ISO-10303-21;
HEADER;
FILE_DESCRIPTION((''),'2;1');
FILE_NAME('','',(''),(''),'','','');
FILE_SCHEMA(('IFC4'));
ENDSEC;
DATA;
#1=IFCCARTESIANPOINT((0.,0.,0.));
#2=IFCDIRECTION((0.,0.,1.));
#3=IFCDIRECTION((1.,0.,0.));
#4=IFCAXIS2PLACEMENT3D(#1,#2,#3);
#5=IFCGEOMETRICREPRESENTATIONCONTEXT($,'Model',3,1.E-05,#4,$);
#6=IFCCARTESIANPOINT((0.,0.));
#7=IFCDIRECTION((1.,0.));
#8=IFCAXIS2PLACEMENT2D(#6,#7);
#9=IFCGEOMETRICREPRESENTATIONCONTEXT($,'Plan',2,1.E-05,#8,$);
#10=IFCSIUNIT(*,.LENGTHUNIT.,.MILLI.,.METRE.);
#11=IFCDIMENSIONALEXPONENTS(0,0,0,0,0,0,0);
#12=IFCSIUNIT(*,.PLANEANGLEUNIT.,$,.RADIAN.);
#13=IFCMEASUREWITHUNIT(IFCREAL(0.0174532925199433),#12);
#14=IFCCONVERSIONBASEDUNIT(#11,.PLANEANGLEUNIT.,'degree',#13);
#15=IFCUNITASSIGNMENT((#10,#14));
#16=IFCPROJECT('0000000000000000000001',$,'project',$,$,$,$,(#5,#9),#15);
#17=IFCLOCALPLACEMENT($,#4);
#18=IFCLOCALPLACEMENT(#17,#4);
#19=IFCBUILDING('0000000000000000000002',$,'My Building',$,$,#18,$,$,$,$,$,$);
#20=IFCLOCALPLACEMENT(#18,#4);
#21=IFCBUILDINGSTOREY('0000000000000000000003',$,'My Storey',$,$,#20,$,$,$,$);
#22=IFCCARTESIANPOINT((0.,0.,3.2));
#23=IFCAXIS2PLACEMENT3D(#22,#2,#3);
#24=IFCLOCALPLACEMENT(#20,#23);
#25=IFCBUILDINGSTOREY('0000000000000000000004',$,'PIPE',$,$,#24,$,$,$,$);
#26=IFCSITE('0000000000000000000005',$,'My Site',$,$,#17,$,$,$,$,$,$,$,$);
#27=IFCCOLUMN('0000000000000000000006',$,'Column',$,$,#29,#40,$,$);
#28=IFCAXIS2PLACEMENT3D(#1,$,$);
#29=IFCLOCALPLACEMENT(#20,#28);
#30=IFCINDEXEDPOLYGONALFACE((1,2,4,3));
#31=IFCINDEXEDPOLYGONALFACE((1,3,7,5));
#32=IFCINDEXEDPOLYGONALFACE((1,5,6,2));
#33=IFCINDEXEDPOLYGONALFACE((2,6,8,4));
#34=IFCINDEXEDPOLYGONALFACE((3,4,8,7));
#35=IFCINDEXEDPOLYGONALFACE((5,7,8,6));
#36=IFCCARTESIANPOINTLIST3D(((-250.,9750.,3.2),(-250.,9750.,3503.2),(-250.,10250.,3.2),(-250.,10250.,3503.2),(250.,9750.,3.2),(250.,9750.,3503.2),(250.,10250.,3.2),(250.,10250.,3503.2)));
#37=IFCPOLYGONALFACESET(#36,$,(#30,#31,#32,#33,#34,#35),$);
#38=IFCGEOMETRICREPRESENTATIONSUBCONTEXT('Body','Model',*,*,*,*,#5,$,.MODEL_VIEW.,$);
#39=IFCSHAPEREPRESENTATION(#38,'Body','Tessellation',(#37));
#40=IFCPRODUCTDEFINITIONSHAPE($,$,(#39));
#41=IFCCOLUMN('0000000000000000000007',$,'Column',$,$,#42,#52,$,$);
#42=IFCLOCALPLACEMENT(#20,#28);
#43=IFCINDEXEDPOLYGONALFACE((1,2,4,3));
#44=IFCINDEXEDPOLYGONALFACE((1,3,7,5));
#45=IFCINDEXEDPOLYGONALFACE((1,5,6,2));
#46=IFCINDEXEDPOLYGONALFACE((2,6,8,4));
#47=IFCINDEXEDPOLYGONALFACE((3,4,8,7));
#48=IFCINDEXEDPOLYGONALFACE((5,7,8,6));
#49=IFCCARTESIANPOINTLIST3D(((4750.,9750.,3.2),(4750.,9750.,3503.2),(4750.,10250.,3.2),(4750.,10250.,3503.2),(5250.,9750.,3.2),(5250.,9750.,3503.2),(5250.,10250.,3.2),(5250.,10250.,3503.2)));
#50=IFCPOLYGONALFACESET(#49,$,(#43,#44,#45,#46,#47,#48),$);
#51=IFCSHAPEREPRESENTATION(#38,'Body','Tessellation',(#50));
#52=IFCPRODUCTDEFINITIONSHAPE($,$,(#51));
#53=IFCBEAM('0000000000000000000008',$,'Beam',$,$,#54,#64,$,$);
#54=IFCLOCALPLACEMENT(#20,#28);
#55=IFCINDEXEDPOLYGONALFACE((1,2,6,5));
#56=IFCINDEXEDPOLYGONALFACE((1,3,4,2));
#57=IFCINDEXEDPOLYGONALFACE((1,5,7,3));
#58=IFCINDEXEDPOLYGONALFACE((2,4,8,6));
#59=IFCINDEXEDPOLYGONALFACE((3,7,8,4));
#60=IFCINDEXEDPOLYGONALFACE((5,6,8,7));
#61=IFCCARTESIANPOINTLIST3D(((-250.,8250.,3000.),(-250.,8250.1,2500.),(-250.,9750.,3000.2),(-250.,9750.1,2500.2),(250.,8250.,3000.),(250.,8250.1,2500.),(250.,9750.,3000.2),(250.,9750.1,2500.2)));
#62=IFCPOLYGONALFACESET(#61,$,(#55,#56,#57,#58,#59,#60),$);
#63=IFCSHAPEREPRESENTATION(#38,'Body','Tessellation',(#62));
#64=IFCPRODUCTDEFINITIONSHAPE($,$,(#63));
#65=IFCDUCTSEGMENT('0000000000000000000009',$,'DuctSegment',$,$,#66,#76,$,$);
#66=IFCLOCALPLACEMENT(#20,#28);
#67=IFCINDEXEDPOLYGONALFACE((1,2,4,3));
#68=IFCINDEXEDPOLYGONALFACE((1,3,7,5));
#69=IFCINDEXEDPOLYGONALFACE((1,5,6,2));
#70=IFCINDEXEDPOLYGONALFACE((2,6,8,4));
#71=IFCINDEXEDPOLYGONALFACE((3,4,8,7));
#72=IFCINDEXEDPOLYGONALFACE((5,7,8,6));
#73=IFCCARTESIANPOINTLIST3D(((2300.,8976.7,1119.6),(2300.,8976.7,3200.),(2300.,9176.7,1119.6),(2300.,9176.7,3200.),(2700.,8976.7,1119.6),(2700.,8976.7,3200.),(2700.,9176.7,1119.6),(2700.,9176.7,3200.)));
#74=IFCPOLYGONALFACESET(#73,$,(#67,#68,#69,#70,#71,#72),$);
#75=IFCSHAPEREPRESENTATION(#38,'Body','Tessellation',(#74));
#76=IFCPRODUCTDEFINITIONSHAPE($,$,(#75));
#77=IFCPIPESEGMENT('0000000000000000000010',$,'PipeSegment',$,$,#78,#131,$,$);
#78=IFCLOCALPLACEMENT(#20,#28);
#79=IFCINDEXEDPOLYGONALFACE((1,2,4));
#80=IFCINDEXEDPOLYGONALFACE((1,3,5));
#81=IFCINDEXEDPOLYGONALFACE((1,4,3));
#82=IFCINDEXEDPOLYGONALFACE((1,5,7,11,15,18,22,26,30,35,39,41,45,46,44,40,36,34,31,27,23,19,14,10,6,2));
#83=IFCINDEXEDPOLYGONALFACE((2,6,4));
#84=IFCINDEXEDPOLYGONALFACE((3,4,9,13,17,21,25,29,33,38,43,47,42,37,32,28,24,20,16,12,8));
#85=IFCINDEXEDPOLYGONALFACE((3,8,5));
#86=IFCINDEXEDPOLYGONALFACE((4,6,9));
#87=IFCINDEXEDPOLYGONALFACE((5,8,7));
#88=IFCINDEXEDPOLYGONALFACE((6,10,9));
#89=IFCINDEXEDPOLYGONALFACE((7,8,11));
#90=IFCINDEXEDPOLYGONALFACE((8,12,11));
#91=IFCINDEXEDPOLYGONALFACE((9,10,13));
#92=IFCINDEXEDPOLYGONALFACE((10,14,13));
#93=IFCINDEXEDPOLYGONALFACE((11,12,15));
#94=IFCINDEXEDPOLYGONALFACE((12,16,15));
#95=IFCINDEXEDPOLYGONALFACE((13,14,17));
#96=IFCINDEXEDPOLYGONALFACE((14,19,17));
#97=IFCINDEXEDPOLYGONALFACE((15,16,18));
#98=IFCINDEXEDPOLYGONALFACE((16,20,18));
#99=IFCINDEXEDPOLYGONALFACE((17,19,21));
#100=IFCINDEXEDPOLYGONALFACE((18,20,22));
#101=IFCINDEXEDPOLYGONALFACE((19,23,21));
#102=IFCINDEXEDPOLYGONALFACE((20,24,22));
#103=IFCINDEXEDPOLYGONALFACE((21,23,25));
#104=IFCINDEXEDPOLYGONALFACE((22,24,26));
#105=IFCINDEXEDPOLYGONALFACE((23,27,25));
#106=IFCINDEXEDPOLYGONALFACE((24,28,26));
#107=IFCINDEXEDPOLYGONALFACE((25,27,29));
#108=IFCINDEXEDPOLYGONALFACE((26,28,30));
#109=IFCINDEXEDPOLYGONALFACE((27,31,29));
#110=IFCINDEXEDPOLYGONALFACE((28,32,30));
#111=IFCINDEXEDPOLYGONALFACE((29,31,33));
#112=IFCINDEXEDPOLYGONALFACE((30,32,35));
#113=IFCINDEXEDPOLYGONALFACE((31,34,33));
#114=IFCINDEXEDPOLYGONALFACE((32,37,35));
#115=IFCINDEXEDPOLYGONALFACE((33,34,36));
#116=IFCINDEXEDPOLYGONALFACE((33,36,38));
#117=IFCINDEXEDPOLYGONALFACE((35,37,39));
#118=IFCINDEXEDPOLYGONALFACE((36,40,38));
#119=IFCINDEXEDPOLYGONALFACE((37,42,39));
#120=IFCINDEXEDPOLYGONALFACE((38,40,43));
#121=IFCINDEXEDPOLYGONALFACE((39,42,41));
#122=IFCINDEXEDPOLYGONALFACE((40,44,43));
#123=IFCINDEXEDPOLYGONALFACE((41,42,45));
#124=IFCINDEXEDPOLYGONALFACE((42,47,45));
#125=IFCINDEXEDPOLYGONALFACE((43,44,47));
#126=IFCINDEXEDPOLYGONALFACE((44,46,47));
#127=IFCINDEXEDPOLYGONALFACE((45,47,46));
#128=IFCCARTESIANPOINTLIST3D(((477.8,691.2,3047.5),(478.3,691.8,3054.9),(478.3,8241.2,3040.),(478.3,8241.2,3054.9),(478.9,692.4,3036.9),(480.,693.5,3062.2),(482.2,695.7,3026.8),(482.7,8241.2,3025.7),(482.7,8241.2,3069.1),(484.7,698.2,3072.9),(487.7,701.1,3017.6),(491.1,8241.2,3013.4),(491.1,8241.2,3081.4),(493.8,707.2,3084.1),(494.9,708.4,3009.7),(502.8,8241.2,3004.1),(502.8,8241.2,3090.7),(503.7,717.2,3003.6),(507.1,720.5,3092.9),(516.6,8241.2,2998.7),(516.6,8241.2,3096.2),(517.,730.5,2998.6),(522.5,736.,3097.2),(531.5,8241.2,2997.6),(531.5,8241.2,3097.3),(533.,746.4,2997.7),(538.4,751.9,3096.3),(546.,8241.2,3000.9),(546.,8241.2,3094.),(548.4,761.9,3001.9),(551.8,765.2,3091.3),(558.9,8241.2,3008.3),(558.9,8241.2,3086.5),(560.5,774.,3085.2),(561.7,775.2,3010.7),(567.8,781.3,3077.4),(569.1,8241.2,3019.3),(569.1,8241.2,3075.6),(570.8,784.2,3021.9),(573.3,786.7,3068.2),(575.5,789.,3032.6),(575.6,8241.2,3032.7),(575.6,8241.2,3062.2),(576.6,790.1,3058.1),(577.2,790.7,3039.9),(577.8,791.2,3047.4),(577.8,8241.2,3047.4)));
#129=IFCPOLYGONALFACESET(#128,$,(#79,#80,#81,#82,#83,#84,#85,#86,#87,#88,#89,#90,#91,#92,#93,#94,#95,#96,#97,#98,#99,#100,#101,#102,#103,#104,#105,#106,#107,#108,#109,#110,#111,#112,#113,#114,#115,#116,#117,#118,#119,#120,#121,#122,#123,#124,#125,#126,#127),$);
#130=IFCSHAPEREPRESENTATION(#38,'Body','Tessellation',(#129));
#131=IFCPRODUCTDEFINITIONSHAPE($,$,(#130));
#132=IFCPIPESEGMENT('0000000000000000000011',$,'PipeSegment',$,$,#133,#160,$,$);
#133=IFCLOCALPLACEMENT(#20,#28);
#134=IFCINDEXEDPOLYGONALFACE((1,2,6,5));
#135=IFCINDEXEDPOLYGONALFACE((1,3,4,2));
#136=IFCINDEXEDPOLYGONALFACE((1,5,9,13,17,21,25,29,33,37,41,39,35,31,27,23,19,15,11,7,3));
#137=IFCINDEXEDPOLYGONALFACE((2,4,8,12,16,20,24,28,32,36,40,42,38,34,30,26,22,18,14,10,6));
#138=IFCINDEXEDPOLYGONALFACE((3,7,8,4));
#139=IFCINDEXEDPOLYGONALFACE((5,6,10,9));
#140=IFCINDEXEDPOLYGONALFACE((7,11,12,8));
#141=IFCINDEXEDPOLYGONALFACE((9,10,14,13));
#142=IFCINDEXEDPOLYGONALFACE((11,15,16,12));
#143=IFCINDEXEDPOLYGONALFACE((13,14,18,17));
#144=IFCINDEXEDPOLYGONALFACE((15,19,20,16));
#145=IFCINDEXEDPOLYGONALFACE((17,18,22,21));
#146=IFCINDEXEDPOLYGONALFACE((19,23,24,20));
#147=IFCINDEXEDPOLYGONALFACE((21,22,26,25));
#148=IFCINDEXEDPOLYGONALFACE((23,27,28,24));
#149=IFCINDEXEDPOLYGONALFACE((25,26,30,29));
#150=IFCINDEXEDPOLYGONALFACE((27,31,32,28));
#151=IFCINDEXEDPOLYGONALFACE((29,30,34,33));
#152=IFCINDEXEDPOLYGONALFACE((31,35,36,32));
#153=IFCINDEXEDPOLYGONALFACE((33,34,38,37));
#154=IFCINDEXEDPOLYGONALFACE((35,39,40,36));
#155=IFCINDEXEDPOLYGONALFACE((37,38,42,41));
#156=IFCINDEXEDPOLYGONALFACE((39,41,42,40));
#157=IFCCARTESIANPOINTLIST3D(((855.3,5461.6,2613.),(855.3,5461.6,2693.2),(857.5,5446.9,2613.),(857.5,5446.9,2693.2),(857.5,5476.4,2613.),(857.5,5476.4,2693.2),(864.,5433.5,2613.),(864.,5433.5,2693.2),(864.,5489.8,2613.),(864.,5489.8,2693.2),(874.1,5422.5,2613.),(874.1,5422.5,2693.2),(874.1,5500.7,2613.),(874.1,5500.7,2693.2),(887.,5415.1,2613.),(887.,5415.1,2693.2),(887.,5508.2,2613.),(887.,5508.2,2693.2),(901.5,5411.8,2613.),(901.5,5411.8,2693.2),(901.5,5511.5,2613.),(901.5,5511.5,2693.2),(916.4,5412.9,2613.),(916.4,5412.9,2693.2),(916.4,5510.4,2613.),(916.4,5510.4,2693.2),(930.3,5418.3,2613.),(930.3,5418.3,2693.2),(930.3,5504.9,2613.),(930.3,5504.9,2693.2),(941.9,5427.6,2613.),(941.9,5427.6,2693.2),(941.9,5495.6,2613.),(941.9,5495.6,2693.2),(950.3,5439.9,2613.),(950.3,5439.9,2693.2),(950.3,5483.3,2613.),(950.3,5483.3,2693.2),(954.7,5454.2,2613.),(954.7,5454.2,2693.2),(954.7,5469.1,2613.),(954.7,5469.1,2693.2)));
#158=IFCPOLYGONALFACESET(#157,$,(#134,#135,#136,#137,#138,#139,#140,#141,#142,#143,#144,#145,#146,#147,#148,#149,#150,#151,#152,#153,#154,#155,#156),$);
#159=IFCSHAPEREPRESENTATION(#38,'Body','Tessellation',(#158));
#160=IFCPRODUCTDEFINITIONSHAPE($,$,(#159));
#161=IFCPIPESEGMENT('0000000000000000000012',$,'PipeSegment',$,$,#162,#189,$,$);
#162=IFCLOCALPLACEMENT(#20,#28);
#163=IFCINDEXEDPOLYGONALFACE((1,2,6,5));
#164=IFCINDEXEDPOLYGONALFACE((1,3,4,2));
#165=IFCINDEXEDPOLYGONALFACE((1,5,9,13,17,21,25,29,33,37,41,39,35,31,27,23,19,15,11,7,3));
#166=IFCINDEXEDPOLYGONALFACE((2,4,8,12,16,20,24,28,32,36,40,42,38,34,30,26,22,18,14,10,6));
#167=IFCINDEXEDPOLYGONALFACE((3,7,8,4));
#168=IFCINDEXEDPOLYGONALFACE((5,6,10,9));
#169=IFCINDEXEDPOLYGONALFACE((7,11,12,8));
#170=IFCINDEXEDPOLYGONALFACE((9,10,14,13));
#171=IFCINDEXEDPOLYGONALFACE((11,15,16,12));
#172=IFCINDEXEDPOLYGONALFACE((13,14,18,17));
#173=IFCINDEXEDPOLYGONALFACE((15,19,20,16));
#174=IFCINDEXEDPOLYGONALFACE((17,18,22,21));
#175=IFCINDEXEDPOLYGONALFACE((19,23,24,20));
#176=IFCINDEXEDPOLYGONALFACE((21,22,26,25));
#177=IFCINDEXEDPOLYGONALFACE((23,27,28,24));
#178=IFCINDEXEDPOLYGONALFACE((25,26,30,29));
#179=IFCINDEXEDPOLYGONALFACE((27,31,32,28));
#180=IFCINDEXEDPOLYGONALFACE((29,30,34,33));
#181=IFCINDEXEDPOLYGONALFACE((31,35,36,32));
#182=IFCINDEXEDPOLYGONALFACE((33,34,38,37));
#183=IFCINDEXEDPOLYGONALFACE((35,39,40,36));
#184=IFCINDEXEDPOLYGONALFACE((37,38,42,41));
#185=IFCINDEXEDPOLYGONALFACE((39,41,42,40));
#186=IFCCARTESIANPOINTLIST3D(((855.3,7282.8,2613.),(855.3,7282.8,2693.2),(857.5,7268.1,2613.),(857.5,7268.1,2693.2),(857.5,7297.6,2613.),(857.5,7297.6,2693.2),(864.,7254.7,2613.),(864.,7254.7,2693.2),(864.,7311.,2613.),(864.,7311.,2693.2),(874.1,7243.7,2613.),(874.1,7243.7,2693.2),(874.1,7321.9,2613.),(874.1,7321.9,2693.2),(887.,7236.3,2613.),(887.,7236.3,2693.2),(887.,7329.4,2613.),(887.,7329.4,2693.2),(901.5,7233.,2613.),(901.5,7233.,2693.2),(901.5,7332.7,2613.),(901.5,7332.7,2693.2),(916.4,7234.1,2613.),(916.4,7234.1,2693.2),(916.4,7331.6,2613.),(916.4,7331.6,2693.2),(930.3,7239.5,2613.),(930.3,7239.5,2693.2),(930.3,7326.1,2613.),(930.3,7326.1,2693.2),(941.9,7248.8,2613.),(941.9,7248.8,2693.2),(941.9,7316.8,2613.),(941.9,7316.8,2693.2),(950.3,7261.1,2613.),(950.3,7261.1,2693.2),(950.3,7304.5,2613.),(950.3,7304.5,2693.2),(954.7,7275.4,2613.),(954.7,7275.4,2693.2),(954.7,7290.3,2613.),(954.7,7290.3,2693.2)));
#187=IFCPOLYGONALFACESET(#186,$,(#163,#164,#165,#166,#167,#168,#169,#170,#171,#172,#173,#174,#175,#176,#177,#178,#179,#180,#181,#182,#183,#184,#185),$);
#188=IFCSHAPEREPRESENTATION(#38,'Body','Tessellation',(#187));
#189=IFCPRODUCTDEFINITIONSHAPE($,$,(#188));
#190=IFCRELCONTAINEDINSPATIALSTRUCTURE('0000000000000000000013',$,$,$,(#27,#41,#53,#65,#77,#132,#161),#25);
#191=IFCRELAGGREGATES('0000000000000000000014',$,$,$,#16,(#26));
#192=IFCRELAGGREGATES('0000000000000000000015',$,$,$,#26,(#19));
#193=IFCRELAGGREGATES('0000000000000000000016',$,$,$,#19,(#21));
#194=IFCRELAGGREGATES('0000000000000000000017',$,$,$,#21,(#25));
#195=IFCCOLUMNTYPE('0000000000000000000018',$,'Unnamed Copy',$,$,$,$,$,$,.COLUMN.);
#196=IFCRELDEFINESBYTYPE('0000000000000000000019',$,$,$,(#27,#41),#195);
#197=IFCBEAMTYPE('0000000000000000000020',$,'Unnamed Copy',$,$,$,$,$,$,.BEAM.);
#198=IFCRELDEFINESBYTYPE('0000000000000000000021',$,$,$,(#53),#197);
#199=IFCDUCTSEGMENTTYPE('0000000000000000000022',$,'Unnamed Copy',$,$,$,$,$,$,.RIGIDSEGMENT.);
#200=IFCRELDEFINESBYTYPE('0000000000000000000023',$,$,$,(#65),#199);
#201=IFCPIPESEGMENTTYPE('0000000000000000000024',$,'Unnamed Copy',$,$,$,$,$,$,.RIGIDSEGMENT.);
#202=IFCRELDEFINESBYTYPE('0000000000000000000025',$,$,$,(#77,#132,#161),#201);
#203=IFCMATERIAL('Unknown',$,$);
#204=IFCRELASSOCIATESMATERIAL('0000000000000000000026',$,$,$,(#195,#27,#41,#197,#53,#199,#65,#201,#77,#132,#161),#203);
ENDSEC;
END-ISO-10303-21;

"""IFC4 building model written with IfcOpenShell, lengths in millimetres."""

from ifc_helpers import new_model, entity, si_unit, converted_unit, frame, origin_with_axes, origin_2d_with_axis, place, context, subcontext, project, spatial, rectangle, circle, extrude, clip, halfspace, material, material_profile, profile_set, profile_usage, type_object, element, save


model = new_model("IFC4")

# Units and contexts
model_context = context("Model", 3, precision=1e-05, world=origin_with_axes())
plan_context = context("Plan", 2, precision=1e-05, world=origin_2d_with_axis())
body_context = subcontext(model_context, "Body", "Model", "MODEL_VIEW")
ifc_project = project(units=[si_unit("LENGTHUNIT", "METRE", prefix="MILLI"), converted_unit("PLANEANGLEUNIT", "degree", entity("IfcReal", 0.0174532925199433), si_unit("PLANEANGLEUNIT", "RADIAN"), dimensions=[0, 0, 0, 0, 0, 0, 0])], contexts=[model_context, plan_context])

# Site, building, storeys
site_placement = place(None, origin_with_axes())
site = spatial("IfcSite", under=ifc_project, at=site_placement, Name="My Site")
building_placement = place(site_placement, origin_with_axes())
building = spatial("IfcBuilding", under=site, at=building_placement, Name="My Building")
storey_1_placement = place(building_placement, origin_with_axes())
storey_1 = spatial("IfcBuildingStorey", under=building, at=storey_1_placement, Name="My Storey")
storey_2_placement = place(storey_1_placement, frame((0.0, 0.0, 3.2), z_axis=(0.0, 0.0, 1.0), x_axis=(1.0, 0.0, 0.0)))
storey_2 = spatial("IfcBuildingStorey", under=storey_1, at=storey_2_placement, Name="PIPE")

# Columns
ifc_material = material(Name="Unknown")
ifc_material_profile_1 = material_profile(ifc_material, rectangle(XDim=500.0, YDim=500.0))
ifc_profile_set_1 = profile_set([ifc_material_profile_1])
ifc_profile_usage_1 = profile_usage(ifc_profile_set_1, cardinal=10)
column_type = type_object("IfcColumnType", Name="Unnamed Copy", PredefinedType="COLUMN", material=ifc_profile_set_1)
column_1_placement = place(storey_2_placement, frame((0.0, 10000.0, 0.0), z_axis=(0.0, 0.0, 1.0), x_axis=(1.0, 0.0, 0.0)))
element("IfcColumn", 1, at=column_1_placement, inside=storey_2, type_object=column_type, material=ifc_profile_usage_1, Name="Column", context=body_context, shape_type="SweptSolid", body=[
    extrude(rectangle(XDim=500.0, YDim=500.0), origin_with_axes(), (0.0, 0.0, 1.0), 3500.0),
])
ifc_profile_usage_2 = profile_usage(ifc_profile_set_1, cardinal=10)
column_2_placement = place(storey_2_placement, frame((5000.0, 10000.0, 0.0), z_axis=(0.0, 0.0, 1.0), x_axis=(1.0, 0.0, 0.0)))
element("IfcColumn", 2, at=column_2_placement, inside=storey_2, type_object=column_type, material=ifc_profile_usage_2, Name="Column", context=body_context, shape_type="SweptSolid", body=[
    extrude(rectangle(XDim=500.0, YDim=500.0), origin_with_axes(), (0.0, 0.0, 1.0), 3500.0),
])

# Beam
ifc_material_profile_2 = material_profile(ifc_material, rectangle(XDim=500.0, YDim=500.0))
ifc_profile_set_2 = profile_set([ifc_material_profile_2])
ifc_profile_usage_3 = profile_usage(ifc_profile_set_2, cardinal=7)
beam_type = type_object("IfcBeamType", Name="Unnamed Copy", PredefinedType="BEAM", material=ifc_profile_set_2)
beam_placement = place(storey_2_placement, frame((-250.0, 8250.0, 2996.8), z_axis=(0.0, 1.0, 0.000133), x_axis=(-1.0, 0.0, 0.0)))
element("IfcBeam", 3, at=beam_placement, inside=storey_2, type_object=beam_type, material=ifc_profile_usage_3, Name="Beam", context=body_context, shape_type="SweptSolid", body=[
    extrude(rectangle(XDim=500.0, YDim=500.0), frame((-250.0, -250.0, 0.0), z_axis=(0.0, 0.0, 1.0), x_axis=(1.0, 0.0, 0.0)), (0.0, 0.0, 1.0), 1500.0),
])

# Duct segment
ifc_material_profile_3 = material_profile(ifc_material, rectangle(XDim=400.0, YDim=200.0))
ifc_profile_set_3 = profile_set([ifc_material_profile_3])
ifc_profile_usage_4 = profile_usage(ifc_profile_set_3, cardinal=10)
duct_segment_type = type_object("IfcDuctSegmentType", Name="Unnamed Copy", PredefinedType="RIGIDSEGMENT", material=ifc_profile_set_3)
duct_segment_placement = place(storey_2_placement, frame((2500.0, 9076.7, 3196.8), z_axis=(0.0, 0.0, -1.0), x_axis=(-1.0, 0.0, 0.0)))
element("IfcDuctSegment", 4, at=duct_segment_placement, inside=storey_2, type_object=duct_segment_type, material=ifc_profile_usage_4, Name="DuctSegment", context=body_context, shape_type="SweptSolid", body=[
    extrude(rectangle(XDim=400.0, YDim=200.0), origin_with_axes(), (0.0, 0.0, 1.0), 2080.4),
])

# Pipe segments
ifc_material_profile_4 = material_profile(ifc_material, circle(Radius=50.0))
ifc_profile_set_4 = profile_set([ifc_material_profile_4])
ifc_profile_usage_5 = profile_usage(ifc_profile_set_4, cardinal=10)
pipe_segment_type = type_object("IfcPipeSegmentType", Name="Unnamed Copy", PredefinedType="RIGIDSEGMENT", material=ifc_profile_set_4)
pipe_segment_1_placement = place(storey_2_placement, frame((527.8, 8241.2, 3044.2), z_axis=(0.0, -1.0, 0.0), x_axis=(1.0, 0.0, 0.0)))
element("IfcPipeSegment", 5, at=pipe_segment_1_placement, inside=storey_2, type_object=pipe_segment_type, material=ifc_profile_usage_5, Name="PipeSegment", context=body_context, shape_type="Clipping", body=[
    clip(extrude(circle(Radius=50.0), origin_with_axes(), (0.0, 0.0, 1.0), 7550.0), halfspace(frame((-50.0, -3000.0, 7550.0), z_axis=(0.707107, 0.0, 0.707107), x_axis=(0.0, -1.0, 0.0)), False)),
])
ifc_profile_usage_6 = profile_usage(ifc_profile_set_4, cardinal=10)
pipe_segment_2_placement = place(storey_2_placement, frame((905.3, 5461.6, 2690.0), z_axis=(0.0, 0.0, -1.0), x_axis=(-1.0, 0.0, 0.0)))
element("IfcPipeSegment", 6, at=pipe_segment_2_placement, inside=storey_2, type_object=pipe_segment_type, material=ifc_profile_usage_6, Name="PipeSegment", context=body_context, shape_type="SweptSolid", body=[
    extrude(circle(Radius=50.0), origin_with_axes(), (0.0, 0.0, 1.0), 80.1),
])
ifc_profile_usage_7 = profile_usage(ifc_profile_set_4, cardinal=10)
pipe_segment_3_placement = place(storey_2_placement, frame((905.3, 7282.8, 2690.0), z_axis=(0.0, 0.0, -1.0), x_axis=(-1.0, 0.0, 0.0)))
element("IfcPipeSegment", 7, at=pipe_segment_3_placement, inside=storey_2, type_object=pipe_segment_type, material=ifc_profile_usage_7, Name="PipeSegment", context=body_context, shape_type="SweptSolid", body=[
    extrude(circle(Radius=50.0), origin_with_axes(), (0.0, 0.0, 1.0), 80.1),
])

save(model, "model.ifc")
